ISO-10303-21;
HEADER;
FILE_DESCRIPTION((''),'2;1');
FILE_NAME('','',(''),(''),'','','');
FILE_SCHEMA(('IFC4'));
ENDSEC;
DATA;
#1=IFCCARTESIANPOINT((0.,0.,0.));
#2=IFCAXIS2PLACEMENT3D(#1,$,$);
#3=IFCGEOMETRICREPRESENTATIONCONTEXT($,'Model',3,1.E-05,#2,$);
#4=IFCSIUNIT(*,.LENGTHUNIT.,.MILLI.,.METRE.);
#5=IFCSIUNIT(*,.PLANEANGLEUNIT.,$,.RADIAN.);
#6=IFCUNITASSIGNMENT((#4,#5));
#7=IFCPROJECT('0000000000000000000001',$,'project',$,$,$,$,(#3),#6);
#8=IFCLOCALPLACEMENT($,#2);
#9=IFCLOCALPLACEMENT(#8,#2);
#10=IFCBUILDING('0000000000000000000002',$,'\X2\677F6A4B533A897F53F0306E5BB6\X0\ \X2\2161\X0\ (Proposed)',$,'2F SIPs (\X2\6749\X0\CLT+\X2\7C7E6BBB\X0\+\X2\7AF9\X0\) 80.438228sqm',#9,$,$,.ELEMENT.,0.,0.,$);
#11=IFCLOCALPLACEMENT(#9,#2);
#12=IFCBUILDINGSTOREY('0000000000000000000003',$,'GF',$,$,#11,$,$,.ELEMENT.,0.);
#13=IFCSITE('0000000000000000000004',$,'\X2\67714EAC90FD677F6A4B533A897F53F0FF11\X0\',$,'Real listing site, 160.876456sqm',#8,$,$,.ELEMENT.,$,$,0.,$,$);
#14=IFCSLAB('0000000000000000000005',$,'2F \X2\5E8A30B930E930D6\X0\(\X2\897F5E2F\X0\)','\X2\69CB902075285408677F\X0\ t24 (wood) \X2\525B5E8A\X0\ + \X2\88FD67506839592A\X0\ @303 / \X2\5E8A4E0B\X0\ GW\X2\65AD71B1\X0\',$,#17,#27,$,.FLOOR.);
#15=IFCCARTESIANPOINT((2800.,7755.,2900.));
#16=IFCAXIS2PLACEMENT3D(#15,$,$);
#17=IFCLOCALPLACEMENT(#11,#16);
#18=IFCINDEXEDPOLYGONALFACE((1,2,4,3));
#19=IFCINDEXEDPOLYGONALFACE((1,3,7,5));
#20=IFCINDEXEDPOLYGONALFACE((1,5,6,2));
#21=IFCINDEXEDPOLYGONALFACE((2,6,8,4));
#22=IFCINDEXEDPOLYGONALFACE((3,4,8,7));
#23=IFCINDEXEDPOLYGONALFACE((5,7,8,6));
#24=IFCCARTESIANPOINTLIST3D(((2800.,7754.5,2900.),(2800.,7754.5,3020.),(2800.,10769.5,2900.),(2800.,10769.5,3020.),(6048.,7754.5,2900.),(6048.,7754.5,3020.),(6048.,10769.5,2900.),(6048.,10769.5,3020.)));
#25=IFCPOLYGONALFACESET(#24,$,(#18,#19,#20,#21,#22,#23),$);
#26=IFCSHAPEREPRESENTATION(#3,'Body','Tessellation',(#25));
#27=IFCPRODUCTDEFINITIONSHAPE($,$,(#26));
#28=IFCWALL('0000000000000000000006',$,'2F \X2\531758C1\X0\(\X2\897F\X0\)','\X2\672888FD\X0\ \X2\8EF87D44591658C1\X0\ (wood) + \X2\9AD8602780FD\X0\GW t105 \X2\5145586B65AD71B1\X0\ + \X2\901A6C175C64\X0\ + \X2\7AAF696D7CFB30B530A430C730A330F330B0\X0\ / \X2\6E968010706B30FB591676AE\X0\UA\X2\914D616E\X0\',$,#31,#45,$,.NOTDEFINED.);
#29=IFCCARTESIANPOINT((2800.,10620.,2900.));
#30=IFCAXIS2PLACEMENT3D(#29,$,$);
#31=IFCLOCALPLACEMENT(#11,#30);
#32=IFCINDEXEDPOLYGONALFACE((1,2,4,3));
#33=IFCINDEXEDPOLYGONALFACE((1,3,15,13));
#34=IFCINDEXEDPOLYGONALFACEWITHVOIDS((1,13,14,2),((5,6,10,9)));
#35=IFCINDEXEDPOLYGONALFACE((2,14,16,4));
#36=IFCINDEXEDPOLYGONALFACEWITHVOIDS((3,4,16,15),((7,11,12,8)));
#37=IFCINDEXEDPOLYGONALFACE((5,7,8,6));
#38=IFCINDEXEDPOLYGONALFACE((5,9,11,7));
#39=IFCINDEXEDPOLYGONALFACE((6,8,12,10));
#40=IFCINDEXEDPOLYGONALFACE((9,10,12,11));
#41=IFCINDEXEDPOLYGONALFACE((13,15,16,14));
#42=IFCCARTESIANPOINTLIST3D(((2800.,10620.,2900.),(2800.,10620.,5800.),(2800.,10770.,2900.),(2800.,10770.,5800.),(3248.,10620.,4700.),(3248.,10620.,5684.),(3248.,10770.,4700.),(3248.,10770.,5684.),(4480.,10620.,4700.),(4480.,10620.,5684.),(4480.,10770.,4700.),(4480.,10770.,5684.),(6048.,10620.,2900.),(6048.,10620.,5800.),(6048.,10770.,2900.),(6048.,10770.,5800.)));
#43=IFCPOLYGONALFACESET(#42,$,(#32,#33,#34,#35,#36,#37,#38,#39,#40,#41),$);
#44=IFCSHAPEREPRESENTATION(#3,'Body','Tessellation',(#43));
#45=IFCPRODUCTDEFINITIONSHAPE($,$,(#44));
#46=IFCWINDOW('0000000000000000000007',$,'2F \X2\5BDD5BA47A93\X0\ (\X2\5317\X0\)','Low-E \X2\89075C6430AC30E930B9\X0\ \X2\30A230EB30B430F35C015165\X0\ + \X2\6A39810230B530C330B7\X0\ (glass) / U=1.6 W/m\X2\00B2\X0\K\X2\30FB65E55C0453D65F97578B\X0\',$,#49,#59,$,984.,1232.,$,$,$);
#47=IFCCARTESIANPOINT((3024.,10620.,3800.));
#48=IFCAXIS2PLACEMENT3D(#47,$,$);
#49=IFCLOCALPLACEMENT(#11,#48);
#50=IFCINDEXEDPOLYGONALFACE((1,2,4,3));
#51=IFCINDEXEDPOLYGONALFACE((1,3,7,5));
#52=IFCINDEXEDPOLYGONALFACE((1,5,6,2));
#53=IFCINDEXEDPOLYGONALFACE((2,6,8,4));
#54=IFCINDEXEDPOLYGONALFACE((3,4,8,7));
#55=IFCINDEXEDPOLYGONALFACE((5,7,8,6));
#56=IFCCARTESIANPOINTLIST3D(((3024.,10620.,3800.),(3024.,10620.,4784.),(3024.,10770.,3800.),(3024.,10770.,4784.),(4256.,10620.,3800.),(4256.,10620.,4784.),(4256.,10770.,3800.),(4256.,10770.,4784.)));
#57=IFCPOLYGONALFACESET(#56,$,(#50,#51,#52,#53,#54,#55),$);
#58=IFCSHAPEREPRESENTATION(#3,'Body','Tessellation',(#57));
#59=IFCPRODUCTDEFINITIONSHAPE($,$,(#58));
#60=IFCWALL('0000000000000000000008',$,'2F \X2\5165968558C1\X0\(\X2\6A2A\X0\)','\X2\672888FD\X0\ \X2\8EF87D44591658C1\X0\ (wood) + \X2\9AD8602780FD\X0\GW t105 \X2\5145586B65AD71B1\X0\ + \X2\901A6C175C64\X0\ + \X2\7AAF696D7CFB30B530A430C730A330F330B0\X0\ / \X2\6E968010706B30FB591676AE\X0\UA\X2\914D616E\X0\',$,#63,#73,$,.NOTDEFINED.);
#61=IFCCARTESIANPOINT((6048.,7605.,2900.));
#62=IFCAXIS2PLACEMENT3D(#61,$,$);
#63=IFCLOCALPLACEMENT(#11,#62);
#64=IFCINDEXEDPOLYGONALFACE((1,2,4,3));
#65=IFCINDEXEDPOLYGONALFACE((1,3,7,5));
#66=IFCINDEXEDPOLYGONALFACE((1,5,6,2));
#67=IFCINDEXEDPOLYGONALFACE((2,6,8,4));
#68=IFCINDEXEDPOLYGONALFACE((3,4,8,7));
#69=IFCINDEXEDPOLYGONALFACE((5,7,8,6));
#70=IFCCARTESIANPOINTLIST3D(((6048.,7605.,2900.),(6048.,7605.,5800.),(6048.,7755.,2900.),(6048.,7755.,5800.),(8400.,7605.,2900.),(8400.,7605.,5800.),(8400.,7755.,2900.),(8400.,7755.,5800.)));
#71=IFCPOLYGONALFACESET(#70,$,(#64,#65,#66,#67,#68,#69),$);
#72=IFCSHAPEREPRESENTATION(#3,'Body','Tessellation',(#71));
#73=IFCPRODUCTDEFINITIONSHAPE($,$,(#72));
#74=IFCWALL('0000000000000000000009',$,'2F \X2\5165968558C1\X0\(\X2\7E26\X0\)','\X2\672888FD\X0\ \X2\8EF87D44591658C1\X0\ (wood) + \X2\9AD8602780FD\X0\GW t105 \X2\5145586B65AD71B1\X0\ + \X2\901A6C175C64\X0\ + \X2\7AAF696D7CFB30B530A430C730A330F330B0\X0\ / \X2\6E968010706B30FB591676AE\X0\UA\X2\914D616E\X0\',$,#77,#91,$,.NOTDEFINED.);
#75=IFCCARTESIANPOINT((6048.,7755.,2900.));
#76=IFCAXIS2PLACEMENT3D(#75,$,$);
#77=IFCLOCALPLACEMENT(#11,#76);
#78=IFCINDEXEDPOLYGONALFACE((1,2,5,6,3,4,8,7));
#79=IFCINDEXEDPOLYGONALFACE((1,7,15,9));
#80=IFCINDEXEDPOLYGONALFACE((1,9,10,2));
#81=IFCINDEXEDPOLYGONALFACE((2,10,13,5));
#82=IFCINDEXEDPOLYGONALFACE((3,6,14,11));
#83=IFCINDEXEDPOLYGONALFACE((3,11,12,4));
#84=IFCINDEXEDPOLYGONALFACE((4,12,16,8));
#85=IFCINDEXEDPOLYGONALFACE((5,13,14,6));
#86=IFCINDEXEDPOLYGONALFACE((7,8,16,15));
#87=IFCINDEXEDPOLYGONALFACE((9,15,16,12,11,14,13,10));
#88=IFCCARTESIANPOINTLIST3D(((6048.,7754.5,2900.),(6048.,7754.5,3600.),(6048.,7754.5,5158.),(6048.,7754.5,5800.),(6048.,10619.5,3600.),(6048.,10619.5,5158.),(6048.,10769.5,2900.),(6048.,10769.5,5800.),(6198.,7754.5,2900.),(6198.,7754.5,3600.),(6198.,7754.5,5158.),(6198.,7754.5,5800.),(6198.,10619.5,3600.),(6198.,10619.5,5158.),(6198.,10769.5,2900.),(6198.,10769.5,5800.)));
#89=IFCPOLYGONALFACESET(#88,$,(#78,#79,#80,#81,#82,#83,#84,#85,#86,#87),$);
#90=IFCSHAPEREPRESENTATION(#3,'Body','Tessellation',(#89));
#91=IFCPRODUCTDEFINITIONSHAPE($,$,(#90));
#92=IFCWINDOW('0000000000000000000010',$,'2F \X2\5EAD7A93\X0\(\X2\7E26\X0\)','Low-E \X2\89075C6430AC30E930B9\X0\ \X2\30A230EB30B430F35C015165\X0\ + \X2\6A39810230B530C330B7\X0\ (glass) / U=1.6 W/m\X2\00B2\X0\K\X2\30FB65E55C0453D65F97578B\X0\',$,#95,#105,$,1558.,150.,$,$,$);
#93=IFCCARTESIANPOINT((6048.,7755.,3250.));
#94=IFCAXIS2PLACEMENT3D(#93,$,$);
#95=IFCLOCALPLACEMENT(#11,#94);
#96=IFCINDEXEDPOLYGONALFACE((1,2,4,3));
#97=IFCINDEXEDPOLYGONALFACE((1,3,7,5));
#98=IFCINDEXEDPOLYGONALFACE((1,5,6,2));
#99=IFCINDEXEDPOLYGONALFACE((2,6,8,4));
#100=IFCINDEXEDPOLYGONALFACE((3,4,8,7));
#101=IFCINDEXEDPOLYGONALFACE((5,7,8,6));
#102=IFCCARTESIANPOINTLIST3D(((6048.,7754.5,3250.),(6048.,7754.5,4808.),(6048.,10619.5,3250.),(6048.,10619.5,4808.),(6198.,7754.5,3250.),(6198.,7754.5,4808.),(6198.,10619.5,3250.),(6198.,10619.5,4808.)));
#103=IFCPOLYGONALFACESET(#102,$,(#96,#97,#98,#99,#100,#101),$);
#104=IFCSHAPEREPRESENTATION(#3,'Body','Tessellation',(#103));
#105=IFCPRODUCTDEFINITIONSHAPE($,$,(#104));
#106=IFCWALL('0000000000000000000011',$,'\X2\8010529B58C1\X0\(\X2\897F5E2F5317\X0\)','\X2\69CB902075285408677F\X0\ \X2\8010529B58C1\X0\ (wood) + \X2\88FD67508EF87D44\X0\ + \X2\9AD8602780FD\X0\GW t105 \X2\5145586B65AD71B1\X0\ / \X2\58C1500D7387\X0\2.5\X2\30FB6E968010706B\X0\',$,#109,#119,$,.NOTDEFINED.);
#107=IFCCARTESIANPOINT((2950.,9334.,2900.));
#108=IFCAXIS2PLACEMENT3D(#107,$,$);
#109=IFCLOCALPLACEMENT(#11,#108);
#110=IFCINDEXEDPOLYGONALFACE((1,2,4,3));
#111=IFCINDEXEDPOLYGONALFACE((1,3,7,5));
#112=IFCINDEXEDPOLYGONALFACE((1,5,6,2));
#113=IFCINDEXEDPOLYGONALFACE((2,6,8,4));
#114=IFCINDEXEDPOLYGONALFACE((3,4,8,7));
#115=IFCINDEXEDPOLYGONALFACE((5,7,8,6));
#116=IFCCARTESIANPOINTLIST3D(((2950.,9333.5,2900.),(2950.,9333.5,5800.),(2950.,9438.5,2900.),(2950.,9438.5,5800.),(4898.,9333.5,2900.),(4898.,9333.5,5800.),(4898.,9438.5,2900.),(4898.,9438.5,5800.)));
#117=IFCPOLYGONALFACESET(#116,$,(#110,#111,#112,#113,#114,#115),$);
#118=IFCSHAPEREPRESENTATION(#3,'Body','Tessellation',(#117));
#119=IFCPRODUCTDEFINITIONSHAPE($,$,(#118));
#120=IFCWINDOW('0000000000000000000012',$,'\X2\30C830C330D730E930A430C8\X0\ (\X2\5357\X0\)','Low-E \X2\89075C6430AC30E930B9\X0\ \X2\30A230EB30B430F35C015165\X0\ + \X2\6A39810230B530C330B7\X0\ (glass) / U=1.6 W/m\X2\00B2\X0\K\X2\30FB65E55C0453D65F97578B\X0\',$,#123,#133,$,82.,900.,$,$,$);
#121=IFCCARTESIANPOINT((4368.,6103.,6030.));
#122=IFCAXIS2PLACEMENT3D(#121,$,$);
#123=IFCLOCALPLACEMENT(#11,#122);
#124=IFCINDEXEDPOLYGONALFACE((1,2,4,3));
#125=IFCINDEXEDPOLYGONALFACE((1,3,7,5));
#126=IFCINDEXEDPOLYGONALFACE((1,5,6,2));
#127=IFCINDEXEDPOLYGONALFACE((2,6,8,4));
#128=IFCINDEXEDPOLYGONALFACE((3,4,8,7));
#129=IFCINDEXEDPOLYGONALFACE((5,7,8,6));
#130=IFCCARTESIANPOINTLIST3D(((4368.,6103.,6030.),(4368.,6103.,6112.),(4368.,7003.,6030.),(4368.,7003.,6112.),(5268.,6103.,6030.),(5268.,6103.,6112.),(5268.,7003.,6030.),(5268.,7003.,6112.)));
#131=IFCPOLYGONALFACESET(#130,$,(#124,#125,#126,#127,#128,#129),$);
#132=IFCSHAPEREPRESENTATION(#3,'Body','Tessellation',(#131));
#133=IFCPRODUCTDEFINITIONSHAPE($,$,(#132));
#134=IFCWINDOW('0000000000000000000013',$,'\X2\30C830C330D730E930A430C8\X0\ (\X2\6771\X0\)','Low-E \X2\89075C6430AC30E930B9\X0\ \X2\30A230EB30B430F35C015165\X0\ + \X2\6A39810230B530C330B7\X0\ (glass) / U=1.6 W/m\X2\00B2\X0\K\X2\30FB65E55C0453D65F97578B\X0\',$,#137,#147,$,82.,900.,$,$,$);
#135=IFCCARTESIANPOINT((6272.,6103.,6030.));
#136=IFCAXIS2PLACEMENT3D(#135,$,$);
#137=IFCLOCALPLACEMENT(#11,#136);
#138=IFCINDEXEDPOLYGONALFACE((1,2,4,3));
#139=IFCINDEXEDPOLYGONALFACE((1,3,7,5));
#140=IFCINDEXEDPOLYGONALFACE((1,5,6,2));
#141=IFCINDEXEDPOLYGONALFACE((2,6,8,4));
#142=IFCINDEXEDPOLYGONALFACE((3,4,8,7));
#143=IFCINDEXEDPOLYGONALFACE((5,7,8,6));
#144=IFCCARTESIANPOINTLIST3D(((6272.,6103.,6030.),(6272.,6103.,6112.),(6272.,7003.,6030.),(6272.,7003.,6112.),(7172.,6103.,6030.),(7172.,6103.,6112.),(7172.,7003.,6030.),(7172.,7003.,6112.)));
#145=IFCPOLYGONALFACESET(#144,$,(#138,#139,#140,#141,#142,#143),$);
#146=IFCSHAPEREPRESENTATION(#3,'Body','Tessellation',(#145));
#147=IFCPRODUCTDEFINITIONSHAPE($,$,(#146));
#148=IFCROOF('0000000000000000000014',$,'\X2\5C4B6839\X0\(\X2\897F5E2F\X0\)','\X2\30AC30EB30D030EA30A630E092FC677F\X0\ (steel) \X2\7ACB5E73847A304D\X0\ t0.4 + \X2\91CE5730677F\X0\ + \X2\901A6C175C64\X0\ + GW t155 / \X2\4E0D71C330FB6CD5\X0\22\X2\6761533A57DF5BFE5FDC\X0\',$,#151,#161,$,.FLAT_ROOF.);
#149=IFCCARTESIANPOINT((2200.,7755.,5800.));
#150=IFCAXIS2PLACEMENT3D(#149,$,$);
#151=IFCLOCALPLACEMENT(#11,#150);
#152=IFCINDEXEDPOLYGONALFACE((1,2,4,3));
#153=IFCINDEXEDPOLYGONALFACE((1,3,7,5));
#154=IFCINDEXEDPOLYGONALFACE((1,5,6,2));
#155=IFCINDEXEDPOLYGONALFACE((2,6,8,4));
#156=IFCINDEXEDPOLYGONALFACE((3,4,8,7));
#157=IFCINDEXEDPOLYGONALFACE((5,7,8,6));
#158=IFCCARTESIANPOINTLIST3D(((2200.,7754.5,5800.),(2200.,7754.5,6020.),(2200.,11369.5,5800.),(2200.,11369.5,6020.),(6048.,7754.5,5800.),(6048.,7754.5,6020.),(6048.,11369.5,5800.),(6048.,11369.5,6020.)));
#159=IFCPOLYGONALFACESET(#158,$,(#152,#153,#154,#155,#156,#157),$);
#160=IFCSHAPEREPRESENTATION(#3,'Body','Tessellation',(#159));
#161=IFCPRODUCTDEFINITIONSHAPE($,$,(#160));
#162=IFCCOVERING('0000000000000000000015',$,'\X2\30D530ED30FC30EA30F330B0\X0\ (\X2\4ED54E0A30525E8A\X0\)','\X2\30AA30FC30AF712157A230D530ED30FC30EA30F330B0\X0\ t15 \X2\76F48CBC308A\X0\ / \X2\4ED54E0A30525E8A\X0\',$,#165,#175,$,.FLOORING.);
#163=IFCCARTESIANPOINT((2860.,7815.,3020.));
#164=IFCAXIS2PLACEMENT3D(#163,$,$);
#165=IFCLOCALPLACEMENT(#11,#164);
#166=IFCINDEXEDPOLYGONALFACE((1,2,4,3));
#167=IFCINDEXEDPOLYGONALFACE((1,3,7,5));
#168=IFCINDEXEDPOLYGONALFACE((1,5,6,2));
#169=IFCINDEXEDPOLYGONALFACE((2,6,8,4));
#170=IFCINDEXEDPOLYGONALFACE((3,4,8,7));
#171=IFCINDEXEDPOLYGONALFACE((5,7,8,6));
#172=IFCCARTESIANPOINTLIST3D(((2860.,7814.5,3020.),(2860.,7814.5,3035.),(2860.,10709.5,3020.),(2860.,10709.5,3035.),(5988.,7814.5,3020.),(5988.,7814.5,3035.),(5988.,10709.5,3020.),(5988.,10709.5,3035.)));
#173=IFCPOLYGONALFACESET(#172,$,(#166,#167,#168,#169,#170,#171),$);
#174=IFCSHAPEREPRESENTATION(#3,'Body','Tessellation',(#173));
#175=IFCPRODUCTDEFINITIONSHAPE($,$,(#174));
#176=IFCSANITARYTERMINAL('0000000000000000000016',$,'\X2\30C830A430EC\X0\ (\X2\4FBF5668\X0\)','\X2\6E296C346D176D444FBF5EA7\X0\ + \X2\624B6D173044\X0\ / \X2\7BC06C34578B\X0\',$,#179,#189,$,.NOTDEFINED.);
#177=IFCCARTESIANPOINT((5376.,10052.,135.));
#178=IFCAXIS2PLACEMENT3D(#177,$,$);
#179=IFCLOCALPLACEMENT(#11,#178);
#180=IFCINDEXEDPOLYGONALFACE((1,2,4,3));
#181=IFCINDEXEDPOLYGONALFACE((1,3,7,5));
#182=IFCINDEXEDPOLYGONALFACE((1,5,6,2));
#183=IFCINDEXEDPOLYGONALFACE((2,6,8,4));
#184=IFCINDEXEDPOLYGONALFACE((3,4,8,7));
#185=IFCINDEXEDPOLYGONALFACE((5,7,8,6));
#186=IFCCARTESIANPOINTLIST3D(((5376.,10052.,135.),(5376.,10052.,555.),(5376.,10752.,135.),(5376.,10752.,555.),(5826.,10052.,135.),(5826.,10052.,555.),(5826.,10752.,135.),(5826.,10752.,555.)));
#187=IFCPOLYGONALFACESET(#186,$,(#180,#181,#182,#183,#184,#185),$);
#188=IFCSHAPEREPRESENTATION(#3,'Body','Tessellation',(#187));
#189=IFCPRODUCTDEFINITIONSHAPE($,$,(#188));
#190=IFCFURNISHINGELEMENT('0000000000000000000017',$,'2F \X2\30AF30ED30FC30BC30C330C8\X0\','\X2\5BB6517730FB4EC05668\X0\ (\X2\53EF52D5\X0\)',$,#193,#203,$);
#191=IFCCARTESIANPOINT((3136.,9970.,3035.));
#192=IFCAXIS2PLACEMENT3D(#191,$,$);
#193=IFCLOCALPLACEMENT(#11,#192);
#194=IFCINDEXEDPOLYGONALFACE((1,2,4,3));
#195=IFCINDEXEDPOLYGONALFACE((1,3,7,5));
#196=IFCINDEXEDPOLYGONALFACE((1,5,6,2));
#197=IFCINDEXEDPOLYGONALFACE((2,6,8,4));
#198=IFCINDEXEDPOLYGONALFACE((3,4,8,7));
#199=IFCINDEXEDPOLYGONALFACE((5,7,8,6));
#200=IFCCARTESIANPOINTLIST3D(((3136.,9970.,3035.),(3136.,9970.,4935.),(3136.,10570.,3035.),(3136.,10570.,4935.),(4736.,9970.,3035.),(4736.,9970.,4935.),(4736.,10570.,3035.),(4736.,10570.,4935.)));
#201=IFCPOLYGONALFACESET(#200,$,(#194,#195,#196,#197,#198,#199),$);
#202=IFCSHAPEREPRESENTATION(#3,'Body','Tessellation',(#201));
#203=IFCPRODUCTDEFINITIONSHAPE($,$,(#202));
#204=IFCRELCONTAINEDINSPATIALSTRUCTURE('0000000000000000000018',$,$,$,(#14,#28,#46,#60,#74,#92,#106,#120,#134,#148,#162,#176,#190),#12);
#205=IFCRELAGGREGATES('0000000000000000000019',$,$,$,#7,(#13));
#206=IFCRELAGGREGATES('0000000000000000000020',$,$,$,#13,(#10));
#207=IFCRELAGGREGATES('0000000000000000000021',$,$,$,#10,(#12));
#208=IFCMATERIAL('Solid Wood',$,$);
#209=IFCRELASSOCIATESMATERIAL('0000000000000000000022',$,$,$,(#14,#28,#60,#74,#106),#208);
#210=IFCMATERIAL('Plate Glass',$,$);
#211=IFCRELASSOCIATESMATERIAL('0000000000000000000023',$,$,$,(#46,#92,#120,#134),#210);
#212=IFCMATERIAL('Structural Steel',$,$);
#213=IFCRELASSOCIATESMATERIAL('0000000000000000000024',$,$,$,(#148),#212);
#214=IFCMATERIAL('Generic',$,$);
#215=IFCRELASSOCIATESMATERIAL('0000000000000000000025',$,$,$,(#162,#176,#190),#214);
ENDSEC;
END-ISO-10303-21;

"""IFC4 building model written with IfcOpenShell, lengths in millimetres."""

from ifc_helpers import new_model, si_unit, frame, frame_2d, origin, place, context, project, spatial, rectangle, extrude, material, element, fill, save


model = new_model("IFC4")

# Units and contexts
model_context = context("Model", 3, precision=1e-05, world=origin())
ifc_project = project(units=[si_unit("LENGTHUNIT", "METRE", prefix="MILLI"), si_unit("PLANEANGLEUNIT", "RADIAN")], contexts=[model_context])

# Site, building, storey
site_placement = place(None, origin())
site = spatial("IfcSite", under=ifc_project, at=site_placement, Name="東京都板橋区西台１", ObjectType="Real listing site, 160.876456sqm", CompositionType="ELEMENT", RefElevation=0.0)
building_placement = place(site_placement, origin())
building = spatial("IfcBuilding", under=site, at=building_placement, Name="板橋区西台の家 Ⅱ (Proposed)", ObjectType="2F SIPs (杉CLT+籾殻+竹) 80.438228sqm", CompositionType="ELEMENT", ElevationOfRefHeight=0.0, ElevationOfTerrain=0.0)
storey_placement = place(building_placement, origin())
storey = spatial("IfcBuildingStorey", under=building, at=storey_placement, Name="GF", CompositionType="ELEMENT", Elevation=0.0)

# Slab
ifc_material_1 = material(Name="Solid Wood")
slab_placement = place(storey_placement, frame((2800.0, 7755.0, 2900.0)))
element("IfcSlab", 1, at=slab_placement, inside=storey, material=ifc_material_1, Name="2F 床スラブ(西帯)", Description="構造用合板 t24 (wood) 剛床 + 製材根太 @303 / 床下 GW断熱", PredefinedType="FLOOR", context=model_context, shape_type="SweptSolid", body=[
    extrude(rectangle(XDim=3248.0, YDim=3015.0, at=frame_2d((1624.0, 1507.0))), frame((2800.0, 7755.0, 2900.0)), (0.0, 0.0, 1.0), 120.0),
])

# Wall, opening, window
wall_1_placement = place(storey_placement, frame((2800.0, 10620.0, 2900.0)))
wall_1 = element("IfcWall", 2, at=wall_1_placement, inside=storey, material=ifc_material_1, Name="2F 北壁(西)", Description="木製 軸組外壁 (wood) + 高性能GW t105 充填断熱 + 通気層 + 窯業系サイディング / 準耐火・外皮UA配慮", PredefinedType="NOTDEFINED", context=model_context, shape_type="SweptSolid", body=[
    extrude(rectangle(XDim=3248.0, YDim=150.0, at=frame_2d((1624.0, 75.0))), frame((2800.0, 10620.0, 2900.0)), (0.0, 0.0, 1.0), 2900.0),
])
opening_1_placement = place(storey_placement, frame((3024.0, 10620.0, 3800.0)))
opening_1 = element("IfcOpeningElement", 3, at=opening_1_placement, cuts=wall_1, PredefinedType="NOTDEFINED", context=model_context, shape_type="SweptSolid", body=[
    extrude(rectangle(XDim=1232.0, YDim=150.0, at=frame_2d((616.0, 75.0))), frame((3024.0, 10620.0, 3800.0)), (0.0, 0.0, 1.0), 984.0),
])
ifc_material_2 = material(Name="Plate Glass")
window_1_placement = place(storey_placement, frame((3024.0, 10620.0, 3800.0)))
window_1 = element("IfcWindow", 4, at=window_1_placement, inside=storey, material=ifc_material_2, Name="2F 寝室窓 (北)", Description="Low-E 複層ガラス アルゴン封入 + 樹脂サッシ (glass) / U=1.6 W/m²K・日射取得型", OverallHeight=984.0, OverallWidth=1232.0, context=model_context, shape_type="SweptSolid", body=[
    extrude(rectangle(XDim=1232.0, YDim=150.0, at=frame_2d((616.0, 75.0))), frame((3024.0, 10620.0, 3800.0)), (0.0, 0.0, 1.0), 984.0),
])
fill(opening_1, window_1)

# Wall
wall_2_placement = place(storey_placement, frame((6048.0, 7605.0, 2900.0)))
element("IfcWall", 5, at=wall_2_placement, inside=storey, material=ifc_material_1, Name="2F 入隅壁(横)", Description="木製 軸組外壁 (wood) + 高性能GW t105 充填断熱 + 通気層 + 窯業系サイディング / 準耐火・外皮UA配慮", PredefinedType="NOTDEFINED", context=model_context, shape_type="SweptSolid", body=[
    extrude(rectangle(XDim=2352.0, YDim=150.0, at=frame_2d((1176.0, 75.0))), frame((6048.0, 7605.0, 2900.0)), (0.0, 0.0, 1.0), 2900.0),
])

# Wall, opening, window
wall_3_placement = place(storey_placement, frame((6048.0, 7755.0, 2900.0)))
wall_3 = element("IfcWall", 6, at=wall_3_placement, inside=storey, material=ifc_material_1, Name="2F 入隅壁(縦)", Description="木製 軸組外壁 (wood) + 高性能GW t105 充填断熱 + 通気層 + 窯業系サイディング / 準耐火・外皮UA配慮", PredefinedType="NOTDEFINED", context=model_context, shape_type="SweptSolid", body=[
    extrude(rectangle(XDim=150.0, YDim=3015.0, at=frame_2d((75.0, 1507.0))), frame((6048.0, 7755.0, 2900.0)), (0.0, 0.0, 1.0), 2900.0),
])
opening_2_placement = place(storey_placement, frame((6048.0, 7755.0, 3250.0)))
opening_2 = element("IfcOpeningElement", 7, at=opening_2_placement, cuts=wall_3, PredefinedType="NOTDEFINED", context=model_context, shape_type="SweptSolid", body=[
    extrude(rectangle(XDim=150.0, YDim=2865.0, at=frame_2d((75.0, 1432.0))), frame((6048.0, 7755.0, 3250.0)), (0.0, 0.0, 1.0), 1558.0),
])
window_2_placement = place(storey_placement, frame((6048.0, 7755.0, 3250.0)))
window_2 = element("IfcWindow", 8, at=window_2_placement, inside=storey, material=ifc_material_2, Name="2F 庭窓(縦)", Description="Low-E 複層ガラス アルゴン封入 + 樹脂サッシ (glass) / U=1.6 W/m²K・日射取得型", OverallHeight=1558.0, OverallWidth=150.0, context=model_context, shape_type="SweptSolid", body=[
    extrude(rectangle(XDim=150.0, YDim=2865.0, at=frame_2d((75.0, 1432.0))), frame((6048.0, 7755.0, 3250.0)), (0.0, 0.0, 1.0), 1558.0),
])
fill(opening_2, window_2)

# Wall
wall_4_placement = place(storey_placement, frame((2950.0, 9334.0, 2900.0)))
element("IfcWall", 9, at=wall_4_placement, inside=storey, material=ifc_material_1, Name="耐力壁(西帯北)", Description="構造用合板 耐力壁 (wood) + 製材軸組 + 高性能GW t105 充填断熱 / 壁倍率2.5・準耐火", PredefinedType="NOTDEFINED", context=model_context, shape_type="SweptSolid", body=[
    extrude(rectangle(XDim=1948.0, YDim=105.0, at=frame_2d((974.0, 52.0))), frame((2950.0, 9334.0, 2900.0)), (0.0, 0.0, 1.0), 2900.0),
])

# Windows
window_3_placement = place(storey_placement, frame((4368.0, 6103.0, 6030.0)))
element("IfcWindow", 10, at=window_3_placement, inside=storey, material=ifc_material_2, Name="トップライト (南)", Description="Low-E 複層ガラス アルゴン封入 + 樹脂サッシ (glass) / U=1.6 W/m²K・日射取得型", OverallHeight=82.0, OverallWidth=900.0, context=model_context, shape_type="SweptSolid", body=[
    extrude(rectangle(XDim=900.0, YDim=900.0, at=frame_2d((450.0, 450.0))), frame((4368.0, 6103.0, 6030.0)), (0.0, 0.0, 1.0), 82.0),
])
window_4_placement = place(storey_placement, frame((6272.0, 6103.0, 6030.0)))
element("IfcWindow", 11, at=window_4_placement, inside=storey, material=ifc_material_2, Name="トップライト (東)", Description="Low-E 複層ガラス アルゴン封入 + 樹脂サッシ (glass) / U=1.6 W/m²K・日射取得型", OverallHeight=82.0, OverallWidth=900.0, context=model_context, shape_type="SweptSolid", body=[
    extrude(rectangle(XDim=900.0, YDim=900.0, at=frame_2d((450.0, 450.0))), frame((6272.0, 6103.0, 6030.0)), (0.0, 0.0, 1.0), 82.0),
])

# Roof
ifc_material_3 = material(Name="Structural Steel")
for number, where, name in (
    (12, (2200.0, 7755.0, 5800.0), "屋根(西帯)"),
):
    element("IfcRoof", number, at=place(storey_placement, frame(where)), inside=storey, material=ifc_material_3, Name=name, Description="ガルバリウム鋼板 (steel) 立平葺き t0.4 + 野地板 + 通気層 + GW t155 / 不燃・法22条区域対応", PredefinedType="FLAT_ROOF", context=model_context, shape_type="SweptSolid", body=[
        extrude(rectangle(XDim=3848.0, YDim=3615.0, at=frame_2d((1924.0, 1807.0))), frame((2200.0, 7755.0, 5800.0)), (0.0, 0.0, 1.0), 220.0),
    ])

# Covering
ifc_material_4 = material(Name="Generic")
covering_placement = place(storey_placement, frame((2860.0, 7815.0, 3020.0)))
element("IfcCovering", 13, at=covering_placement, inside=storey, material=ifc_material_4, Name="フローリング (仕上げ床)", Description="オーク無垢フローリング t15 直貼り / 仕上げ床", PredefinedType="FLOORING", context=model_context, shape_type="SweptSolid", body=[
    extrude(rectangle(XDim=3128.0, YDim=2895.0, at=frame_2d((1564.0, 1447.0))), frame((2860.0, 7815.0, 3020.0)), (0.0, 0.0, 1.0), 15.0),
])

# Sanitary terminal
sanitary_terminal_placement = place(storey_placement, frame((5376.0, 10052.0, 135.0)))
element("IfcSanitaryTerminal", 14, at=sanitary_terminal_placement, inside=storey, material=ifc_material_4, Name="トイレ (便器)", Description="温水洗浄便座 + 手洗い / 節水型", PredefinedType="NOTDEFINED", context=model_context, shape_type="SweptSolid", body=[
    extrude(rectangle(XDim=450.0, YDim=700.0, at=frame_2d((225.0, 350.0))), frame((5376.0, 10052.0, 135.0)), (0.0, 0.0, 1.0), 420.0),
])

# Furnishing element
furnishing_1_placement = place(storey_placement, frame((3136.0, 9970.0, 3035.0)))
element("IfcFurnishingElement", 15, at=furnishing_1_placement, inside=storey, material=ifc_material_4, Name="2F クローゼット", Description="家具・什器 (可動)", context=model_context, shape_type="SweptSolid", body=[
    extrude(rectangle(XDim=1600.0, YDim=600.0, at=frame_2d((800.0, 300.0))), frame((3136.0, 9970.0, 3035.0)), (0.0, 0.0, 1.0), 1900.0),
])

save(model, "model.ifc")
